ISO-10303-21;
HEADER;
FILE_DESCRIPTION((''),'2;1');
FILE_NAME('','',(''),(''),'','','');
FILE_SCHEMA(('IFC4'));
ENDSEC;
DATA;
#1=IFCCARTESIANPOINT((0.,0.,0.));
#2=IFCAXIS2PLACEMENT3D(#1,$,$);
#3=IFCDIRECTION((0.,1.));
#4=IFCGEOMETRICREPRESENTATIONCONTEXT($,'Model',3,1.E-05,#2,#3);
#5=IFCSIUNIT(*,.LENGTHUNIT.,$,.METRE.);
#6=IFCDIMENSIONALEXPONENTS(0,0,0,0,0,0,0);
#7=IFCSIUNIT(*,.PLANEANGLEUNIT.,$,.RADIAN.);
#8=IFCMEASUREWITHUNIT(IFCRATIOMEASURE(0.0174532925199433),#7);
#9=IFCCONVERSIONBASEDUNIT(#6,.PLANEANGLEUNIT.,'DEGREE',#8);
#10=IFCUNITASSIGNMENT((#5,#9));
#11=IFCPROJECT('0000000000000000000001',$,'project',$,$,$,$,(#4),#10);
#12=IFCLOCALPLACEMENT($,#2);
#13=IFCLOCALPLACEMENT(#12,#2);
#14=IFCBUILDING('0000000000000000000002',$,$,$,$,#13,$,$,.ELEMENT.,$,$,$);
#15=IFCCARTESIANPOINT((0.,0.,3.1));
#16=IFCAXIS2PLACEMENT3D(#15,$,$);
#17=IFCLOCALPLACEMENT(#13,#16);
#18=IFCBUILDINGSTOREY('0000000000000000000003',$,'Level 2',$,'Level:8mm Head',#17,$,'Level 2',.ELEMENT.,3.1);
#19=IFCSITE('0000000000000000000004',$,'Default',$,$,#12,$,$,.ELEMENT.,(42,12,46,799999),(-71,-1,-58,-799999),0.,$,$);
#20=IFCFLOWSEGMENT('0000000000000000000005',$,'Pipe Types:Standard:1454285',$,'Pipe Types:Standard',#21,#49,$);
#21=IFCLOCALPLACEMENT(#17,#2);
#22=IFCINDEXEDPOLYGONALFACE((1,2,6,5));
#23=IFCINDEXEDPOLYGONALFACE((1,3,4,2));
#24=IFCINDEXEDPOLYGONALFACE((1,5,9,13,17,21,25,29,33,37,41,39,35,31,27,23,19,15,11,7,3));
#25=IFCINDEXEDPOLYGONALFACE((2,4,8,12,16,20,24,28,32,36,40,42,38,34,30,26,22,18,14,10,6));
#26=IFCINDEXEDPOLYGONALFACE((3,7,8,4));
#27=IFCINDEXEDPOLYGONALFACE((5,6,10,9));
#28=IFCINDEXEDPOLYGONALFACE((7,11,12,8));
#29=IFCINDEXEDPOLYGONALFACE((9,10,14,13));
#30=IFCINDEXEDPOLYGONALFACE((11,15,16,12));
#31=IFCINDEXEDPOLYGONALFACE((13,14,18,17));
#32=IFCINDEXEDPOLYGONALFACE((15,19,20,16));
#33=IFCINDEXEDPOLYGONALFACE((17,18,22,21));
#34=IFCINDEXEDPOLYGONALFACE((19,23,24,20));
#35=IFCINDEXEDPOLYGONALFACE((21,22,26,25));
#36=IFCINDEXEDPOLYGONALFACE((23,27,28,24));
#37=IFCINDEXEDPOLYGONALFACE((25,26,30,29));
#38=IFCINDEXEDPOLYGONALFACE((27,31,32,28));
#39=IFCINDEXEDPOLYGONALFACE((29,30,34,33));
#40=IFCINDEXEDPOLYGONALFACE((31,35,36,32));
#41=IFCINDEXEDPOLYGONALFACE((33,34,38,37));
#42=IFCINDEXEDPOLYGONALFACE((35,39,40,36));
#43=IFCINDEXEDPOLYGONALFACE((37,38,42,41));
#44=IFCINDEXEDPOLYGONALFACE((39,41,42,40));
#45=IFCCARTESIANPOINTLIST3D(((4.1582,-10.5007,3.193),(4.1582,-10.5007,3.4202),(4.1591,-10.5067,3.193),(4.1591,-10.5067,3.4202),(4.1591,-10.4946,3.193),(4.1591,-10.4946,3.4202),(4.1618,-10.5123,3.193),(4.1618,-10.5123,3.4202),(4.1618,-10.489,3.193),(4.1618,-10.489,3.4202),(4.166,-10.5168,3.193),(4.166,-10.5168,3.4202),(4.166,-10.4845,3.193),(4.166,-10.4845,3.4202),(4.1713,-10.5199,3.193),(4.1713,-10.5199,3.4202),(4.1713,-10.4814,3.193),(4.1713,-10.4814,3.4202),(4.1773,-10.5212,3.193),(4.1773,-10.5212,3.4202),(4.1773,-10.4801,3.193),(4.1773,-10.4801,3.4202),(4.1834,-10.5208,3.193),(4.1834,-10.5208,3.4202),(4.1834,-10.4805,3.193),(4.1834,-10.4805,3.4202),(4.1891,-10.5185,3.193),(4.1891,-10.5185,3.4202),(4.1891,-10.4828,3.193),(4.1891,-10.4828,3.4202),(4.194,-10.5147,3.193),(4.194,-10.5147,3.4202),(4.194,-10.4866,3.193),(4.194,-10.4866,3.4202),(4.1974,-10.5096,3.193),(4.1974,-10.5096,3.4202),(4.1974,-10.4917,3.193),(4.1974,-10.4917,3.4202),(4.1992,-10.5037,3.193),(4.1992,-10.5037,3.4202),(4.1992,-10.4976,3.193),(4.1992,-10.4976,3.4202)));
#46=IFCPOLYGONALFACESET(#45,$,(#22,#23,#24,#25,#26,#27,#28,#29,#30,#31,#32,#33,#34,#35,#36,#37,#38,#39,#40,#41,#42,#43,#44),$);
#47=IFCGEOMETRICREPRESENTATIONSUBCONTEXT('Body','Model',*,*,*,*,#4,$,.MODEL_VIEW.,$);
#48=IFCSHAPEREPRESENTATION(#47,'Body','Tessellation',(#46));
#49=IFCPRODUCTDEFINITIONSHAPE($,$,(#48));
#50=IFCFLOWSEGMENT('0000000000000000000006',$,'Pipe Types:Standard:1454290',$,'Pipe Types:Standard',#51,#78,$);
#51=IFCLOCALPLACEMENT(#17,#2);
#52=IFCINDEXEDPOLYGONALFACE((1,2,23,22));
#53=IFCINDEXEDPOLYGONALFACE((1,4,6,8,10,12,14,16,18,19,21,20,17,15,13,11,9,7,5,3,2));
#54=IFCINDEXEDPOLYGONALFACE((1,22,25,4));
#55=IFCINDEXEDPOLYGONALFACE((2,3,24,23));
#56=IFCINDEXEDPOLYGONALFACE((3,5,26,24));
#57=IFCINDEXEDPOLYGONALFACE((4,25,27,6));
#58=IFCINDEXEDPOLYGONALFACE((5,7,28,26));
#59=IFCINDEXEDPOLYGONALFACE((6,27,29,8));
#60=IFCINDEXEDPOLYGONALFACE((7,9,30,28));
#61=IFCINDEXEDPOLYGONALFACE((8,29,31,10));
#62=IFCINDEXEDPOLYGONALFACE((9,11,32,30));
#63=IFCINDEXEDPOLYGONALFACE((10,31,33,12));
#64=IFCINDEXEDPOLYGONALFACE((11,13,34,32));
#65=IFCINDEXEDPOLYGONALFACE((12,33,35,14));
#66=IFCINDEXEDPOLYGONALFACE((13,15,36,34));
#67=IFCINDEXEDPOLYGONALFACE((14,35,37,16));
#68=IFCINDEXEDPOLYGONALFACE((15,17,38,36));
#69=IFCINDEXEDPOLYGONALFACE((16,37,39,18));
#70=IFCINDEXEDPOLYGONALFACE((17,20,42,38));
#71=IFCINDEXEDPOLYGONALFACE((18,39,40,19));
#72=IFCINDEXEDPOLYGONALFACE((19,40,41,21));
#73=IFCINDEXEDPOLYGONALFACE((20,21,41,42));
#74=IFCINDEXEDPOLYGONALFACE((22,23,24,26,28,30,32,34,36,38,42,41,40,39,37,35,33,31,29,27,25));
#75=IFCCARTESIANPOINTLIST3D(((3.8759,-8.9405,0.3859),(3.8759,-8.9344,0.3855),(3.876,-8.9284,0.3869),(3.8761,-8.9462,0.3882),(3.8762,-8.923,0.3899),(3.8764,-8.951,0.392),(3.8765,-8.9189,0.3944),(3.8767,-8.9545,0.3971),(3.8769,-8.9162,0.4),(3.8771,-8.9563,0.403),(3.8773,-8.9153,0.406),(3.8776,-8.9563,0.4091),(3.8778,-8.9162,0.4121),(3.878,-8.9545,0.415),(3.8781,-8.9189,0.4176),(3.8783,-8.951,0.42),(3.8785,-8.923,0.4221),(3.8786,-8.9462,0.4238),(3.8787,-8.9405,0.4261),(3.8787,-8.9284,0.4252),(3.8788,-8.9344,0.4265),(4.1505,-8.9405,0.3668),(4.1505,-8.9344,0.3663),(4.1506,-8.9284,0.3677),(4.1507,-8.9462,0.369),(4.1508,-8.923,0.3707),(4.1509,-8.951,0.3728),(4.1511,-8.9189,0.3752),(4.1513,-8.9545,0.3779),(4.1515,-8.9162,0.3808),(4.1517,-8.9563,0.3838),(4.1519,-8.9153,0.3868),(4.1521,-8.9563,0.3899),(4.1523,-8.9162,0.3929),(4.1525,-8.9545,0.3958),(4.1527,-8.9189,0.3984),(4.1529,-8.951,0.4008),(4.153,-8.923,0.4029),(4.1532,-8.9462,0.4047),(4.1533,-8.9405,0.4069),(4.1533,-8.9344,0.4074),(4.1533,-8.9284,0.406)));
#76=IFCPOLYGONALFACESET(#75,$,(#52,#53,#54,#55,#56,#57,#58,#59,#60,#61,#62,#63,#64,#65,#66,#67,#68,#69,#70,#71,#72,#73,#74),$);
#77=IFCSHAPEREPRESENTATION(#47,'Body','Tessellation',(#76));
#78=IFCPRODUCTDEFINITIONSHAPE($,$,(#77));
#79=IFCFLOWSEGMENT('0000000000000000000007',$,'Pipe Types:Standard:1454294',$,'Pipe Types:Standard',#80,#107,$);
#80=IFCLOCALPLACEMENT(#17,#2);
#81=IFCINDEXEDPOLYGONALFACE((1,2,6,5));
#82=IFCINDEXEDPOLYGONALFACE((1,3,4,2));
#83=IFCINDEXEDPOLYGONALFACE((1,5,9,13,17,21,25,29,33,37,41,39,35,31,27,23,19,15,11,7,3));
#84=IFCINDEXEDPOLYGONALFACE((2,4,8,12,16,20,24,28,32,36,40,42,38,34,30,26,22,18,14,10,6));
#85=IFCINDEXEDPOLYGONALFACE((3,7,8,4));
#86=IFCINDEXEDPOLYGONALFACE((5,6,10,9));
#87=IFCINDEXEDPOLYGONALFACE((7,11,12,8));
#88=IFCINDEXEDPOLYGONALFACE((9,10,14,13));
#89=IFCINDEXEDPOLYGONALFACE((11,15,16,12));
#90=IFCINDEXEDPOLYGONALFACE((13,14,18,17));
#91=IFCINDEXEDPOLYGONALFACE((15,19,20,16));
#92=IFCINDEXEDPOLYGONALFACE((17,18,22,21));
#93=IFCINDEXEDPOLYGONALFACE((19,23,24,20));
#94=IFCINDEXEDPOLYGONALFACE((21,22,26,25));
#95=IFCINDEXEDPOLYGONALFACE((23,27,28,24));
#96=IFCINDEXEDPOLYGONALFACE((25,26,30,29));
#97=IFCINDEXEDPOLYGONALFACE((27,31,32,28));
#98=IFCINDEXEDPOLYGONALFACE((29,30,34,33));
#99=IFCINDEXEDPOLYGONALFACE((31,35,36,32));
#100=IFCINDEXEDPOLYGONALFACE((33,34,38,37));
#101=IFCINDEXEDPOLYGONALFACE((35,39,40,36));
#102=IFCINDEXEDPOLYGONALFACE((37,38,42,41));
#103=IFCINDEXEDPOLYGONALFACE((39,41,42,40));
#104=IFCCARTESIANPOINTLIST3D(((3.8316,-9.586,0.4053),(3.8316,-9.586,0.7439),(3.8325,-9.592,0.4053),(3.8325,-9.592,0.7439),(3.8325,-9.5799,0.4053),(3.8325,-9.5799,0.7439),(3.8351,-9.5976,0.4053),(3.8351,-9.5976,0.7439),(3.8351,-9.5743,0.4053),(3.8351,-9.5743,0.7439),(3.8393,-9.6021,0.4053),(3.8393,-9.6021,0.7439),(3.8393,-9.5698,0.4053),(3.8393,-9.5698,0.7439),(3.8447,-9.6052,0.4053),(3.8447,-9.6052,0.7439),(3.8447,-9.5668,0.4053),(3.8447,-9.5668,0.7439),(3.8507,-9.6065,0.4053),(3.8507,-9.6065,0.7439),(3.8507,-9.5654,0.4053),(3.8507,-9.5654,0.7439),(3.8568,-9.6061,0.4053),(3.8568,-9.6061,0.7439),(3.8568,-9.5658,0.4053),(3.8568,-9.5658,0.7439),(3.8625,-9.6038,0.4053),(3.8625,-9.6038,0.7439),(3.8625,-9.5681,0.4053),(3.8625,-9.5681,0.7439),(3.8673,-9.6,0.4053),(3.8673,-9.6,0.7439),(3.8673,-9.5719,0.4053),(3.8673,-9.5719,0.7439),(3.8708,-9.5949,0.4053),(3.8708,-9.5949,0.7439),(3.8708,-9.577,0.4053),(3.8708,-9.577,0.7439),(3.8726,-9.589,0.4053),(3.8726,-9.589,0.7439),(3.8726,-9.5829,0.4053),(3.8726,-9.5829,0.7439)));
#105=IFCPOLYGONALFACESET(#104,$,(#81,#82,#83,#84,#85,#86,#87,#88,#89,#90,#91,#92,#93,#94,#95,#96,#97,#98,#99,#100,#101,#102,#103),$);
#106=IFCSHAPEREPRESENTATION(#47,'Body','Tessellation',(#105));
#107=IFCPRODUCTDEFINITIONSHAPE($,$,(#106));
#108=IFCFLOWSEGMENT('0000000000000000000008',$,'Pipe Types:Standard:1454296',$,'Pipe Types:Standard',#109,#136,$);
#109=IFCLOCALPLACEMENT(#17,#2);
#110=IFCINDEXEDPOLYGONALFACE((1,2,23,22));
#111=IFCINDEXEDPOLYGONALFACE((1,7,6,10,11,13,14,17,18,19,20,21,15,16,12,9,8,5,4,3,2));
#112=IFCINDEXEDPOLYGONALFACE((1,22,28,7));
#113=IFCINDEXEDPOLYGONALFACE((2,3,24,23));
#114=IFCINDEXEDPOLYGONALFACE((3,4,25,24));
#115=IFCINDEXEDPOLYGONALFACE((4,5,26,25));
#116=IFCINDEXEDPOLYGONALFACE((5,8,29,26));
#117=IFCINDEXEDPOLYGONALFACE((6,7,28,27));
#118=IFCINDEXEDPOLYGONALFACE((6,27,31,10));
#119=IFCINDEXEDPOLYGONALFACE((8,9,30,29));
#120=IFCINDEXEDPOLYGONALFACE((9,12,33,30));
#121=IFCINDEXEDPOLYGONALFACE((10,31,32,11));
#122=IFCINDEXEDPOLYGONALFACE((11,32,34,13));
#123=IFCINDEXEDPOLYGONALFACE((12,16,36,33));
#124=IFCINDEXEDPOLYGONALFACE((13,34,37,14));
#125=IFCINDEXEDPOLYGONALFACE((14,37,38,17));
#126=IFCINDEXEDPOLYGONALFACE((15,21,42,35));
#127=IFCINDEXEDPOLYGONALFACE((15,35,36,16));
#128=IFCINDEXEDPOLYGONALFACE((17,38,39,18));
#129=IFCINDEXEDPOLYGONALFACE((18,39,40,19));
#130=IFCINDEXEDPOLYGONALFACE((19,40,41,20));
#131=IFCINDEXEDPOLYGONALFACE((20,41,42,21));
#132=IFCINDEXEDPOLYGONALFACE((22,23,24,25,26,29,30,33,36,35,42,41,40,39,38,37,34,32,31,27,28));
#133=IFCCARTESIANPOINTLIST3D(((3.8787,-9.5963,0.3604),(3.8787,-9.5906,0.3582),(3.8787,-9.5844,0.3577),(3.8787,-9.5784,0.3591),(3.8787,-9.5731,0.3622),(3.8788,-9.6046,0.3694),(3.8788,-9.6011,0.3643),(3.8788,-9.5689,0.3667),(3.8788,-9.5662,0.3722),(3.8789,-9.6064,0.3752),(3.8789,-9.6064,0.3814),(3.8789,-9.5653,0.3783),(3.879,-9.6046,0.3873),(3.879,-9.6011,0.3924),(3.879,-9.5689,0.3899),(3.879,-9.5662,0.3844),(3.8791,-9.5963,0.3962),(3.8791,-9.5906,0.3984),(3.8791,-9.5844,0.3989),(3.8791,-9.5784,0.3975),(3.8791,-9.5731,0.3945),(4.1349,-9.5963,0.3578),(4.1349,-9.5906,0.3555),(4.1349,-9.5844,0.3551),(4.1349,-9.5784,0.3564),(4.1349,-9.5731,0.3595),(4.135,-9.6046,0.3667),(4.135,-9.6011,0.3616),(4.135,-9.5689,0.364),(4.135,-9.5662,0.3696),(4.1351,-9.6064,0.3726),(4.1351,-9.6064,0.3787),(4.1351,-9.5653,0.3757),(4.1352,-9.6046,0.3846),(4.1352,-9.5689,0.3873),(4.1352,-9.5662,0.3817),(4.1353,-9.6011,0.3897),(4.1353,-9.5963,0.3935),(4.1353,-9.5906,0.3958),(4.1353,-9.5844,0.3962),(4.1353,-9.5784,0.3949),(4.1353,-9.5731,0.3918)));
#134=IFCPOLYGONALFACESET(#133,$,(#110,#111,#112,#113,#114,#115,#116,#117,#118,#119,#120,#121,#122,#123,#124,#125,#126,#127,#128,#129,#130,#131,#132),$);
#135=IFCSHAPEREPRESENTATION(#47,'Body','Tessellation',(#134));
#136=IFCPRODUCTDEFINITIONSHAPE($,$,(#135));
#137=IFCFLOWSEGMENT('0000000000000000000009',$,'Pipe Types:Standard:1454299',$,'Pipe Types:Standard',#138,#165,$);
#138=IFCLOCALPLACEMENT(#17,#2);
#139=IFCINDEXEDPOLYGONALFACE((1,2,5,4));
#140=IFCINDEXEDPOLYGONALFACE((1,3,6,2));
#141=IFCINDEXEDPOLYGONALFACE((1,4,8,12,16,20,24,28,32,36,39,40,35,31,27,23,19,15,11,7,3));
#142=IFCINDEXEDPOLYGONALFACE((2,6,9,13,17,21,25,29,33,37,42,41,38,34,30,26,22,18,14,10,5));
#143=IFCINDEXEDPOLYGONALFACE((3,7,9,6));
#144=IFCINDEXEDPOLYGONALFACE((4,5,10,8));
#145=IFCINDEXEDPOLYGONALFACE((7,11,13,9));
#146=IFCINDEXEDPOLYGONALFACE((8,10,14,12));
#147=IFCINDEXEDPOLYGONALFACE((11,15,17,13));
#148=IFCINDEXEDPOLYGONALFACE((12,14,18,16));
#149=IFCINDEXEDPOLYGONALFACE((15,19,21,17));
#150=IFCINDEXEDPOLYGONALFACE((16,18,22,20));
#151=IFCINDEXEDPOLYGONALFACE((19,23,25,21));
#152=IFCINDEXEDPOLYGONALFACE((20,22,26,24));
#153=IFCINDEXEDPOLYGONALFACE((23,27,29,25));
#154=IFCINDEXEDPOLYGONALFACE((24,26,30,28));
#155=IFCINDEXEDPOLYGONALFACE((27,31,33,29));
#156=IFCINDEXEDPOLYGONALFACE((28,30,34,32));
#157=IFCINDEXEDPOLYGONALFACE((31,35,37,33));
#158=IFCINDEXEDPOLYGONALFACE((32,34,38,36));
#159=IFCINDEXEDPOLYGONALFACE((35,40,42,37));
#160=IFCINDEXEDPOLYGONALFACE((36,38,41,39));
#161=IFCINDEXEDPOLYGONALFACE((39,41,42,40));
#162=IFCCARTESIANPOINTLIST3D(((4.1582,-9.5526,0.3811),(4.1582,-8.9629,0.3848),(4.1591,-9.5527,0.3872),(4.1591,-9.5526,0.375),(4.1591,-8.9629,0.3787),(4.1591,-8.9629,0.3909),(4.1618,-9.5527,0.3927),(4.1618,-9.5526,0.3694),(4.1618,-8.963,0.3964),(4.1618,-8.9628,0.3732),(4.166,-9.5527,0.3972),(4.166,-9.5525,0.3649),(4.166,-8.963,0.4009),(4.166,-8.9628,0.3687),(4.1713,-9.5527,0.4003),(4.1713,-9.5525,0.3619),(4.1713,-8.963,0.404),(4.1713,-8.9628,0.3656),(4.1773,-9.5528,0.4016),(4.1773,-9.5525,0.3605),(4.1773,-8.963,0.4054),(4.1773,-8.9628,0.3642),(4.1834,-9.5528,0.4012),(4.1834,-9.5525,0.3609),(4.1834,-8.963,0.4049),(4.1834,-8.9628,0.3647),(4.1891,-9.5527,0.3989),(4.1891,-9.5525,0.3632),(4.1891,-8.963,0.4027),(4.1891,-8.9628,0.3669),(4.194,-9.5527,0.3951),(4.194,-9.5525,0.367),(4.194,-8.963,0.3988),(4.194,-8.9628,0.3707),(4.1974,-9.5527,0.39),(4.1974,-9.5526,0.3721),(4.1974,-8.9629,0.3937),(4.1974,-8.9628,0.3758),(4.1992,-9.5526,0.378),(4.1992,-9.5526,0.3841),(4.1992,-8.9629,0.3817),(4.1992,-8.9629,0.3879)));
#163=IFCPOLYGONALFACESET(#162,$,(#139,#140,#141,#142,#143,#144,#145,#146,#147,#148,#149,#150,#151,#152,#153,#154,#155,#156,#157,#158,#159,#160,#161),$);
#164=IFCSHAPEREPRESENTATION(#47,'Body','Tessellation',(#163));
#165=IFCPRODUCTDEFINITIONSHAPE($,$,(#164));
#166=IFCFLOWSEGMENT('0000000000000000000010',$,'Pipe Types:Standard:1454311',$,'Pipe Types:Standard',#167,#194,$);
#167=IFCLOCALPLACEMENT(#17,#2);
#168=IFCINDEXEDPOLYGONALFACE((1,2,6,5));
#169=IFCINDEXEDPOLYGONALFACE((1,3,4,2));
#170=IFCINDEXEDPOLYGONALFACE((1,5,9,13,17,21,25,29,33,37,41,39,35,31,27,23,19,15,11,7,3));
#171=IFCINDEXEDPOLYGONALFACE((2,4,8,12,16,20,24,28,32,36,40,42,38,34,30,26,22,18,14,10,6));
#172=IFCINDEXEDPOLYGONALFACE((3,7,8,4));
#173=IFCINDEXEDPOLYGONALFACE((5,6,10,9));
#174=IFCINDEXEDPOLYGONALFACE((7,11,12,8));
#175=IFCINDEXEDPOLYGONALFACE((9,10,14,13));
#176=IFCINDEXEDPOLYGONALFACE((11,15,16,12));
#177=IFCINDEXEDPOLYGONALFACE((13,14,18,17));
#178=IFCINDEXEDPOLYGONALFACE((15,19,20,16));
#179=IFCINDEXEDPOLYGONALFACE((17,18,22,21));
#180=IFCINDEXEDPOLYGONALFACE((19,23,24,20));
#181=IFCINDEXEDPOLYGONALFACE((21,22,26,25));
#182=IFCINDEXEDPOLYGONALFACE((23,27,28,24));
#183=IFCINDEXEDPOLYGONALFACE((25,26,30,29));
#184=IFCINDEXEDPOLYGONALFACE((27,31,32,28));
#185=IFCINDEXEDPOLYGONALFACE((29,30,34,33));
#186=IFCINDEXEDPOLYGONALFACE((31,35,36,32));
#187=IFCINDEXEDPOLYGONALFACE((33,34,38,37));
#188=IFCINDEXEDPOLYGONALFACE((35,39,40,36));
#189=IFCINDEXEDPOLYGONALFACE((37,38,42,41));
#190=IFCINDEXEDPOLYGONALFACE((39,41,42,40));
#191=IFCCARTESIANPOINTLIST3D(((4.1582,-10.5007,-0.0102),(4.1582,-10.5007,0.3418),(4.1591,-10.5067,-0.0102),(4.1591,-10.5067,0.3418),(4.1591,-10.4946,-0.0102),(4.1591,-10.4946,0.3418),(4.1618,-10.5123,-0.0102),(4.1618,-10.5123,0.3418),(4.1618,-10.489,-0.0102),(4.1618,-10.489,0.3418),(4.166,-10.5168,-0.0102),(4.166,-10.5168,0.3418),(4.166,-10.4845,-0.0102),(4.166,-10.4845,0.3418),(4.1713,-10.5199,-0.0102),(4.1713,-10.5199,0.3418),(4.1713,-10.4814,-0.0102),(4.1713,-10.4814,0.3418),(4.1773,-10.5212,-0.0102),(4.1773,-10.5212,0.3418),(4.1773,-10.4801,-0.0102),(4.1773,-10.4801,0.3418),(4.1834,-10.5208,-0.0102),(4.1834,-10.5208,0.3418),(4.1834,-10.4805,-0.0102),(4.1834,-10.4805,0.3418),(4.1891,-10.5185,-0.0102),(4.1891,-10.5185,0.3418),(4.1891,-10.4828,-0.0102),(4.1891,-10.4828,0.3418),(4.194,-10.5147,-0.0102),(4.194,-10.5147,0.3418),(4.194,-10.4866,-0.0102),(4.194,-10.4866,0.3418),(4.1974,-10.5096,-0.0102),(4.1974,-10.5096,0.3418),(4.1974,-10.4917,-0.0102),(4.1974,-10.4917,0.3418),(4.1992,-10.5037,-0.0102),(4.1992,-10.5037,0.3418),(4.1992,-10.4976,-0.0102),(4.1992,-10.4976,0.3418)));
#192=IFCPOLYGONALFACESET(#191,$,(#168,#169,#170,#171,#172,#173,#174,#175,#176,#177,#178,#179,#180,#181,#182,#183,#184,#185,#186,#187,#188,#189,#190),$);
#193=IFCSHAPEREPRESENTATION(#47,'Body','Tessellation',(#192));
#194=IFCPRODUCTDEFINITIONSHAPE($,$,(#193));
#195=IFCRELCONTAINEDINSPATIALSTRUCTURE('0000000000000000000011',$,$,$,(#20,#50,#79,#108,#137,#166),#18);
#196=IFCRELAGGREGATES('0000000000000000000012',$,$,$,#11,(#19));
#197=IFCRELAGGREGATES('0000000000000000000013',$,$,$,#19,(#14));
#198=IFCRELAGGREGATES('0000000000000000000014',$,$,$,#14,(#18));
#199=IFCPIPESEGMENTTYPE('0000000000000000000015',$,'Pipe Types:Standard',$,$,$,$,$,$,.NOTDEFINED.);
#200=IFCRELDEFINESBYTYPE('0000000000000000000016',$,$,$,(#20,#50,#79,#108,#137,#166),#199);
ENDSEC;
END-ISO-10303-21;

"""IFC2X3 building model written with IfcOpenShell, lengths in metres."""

from ifc_helpers import new_model, entity, si_unit, converted_unit, direction, frame, frame_2d, origin, origin_2d_with_axis, place, context, subcontext, project, spatial, circle, extrude, type_object, element, save


model = new_model("IFC2X3")

# Units and contexts
model_context = context("Model", 3, precision=1e-05, world=origin(), true_north=direction((0.0, 1.0)))
body_context = subcontext(model_context, "Body", "Model", "MODEL_VIEW")
ifc_project = project(units=[si_unit("LENGTHUNIT", "METRE"), converted_unit("PLANEANGLEUNIT", "DEGREE", entity("IfcRatioMeasure", 0.0174532925199433), si_unit("PLANEANGLEUNIT", "RADIAN"), dimensions=[0, 0, 0, 0, 0, 0, 0])], contexts=[model_context])

# Site, building, storey
site_placement = place(None, origin())
site = spatial("IfcSite", under=ifc_project, at=site_placement, Name="Default", CompositionType="ELEMENT", RefLatitude=(42, 12, 46, 799999), RefLongitude=(-71, -1, -58, -799999), RefElevation=0.0)
building_placement = place(site_placement, origin())
building = spatial("IfcBuilding", under=site, at=building_placement, CompositionType="ELEMENT")
storey_placement = place(building_placement, frame((0.0, 0.0, 3.1)))
storey = spatial("IfcBuildingStorey", under=building, at=storey_placement, Name="Level 2", ObjectType="Level:8mm Head", LongName="Level 2", CompositionType="ELEMENT", Elevation=3.1)

# Flow segments
pipe_segment_type = type_object("IfcPipeSegmentType", Name="Pipe Types:Standard", PredefinedType="NOTDEFINED")
flow_segment_1_placement = place(storey_placement, origin())
element("IfcFlowSegment", 1, at=flow_segment_1_placement, inside=storey, type_object=pipe_segment_type, Name="Pipe Types:Standard:1454285", ObjectType="Pipe Types:Standard", context=body_context, shape_type="SweptSolid", body=[
    extrude(circle(Radius=0.0206, at=origin_2d_with_axis()), frame((4.1788, -10.5007, 3.193), z_axis=(0.0, 0.0, 1.0), x_axis=(-1.0, 0.0, 0.0)), (0.0, 0.0, 1.0), 0.2272),
])
flow_segment_2_placement = place(storey_placement, origin())
element("IfcFlowSegment", 2, at=flow_segment_2_placement, inside=storey, type_object=pipe_segment_type, Name="Pipe Types:Standard:1454290", ObjectType="Pipe Types:Standard", context=body_context, shape_type="SweptSolid", body=[
    extrude(circle(Radius=0.0206, at=origin_2d_with_axis()), frame((3.8773, -8.9359, 0.406), z_axis=(0.997568, 0.0, -0.069693), x_axis=(0.0, 1.0, 0.0)), (0.0, 0.0, 1.0), 0.2752),
])
flow_segment_3_placement = place(storey_placement, origin())
element("IfcFlowSegment", 3, at=flow_segment_3_placement, inside=storey, type_object=pipe_segment_type, Name="Pipe Types:Standard:1454294", ObjectType="Pipe Types:Standard", context=body_context, shape_type="SweptSolid", body=[
    extrude(circle(Radius=0.0206, at=frame_2d((0.0, 0.0), x_axis=(1.0, 0.0))), frame((3.8522, -9.586, 0.4053), z_axis=(0.000016, 0.0, 1.0), x_axis=(-1.0, 0.0, 0.000016)), (0.0, 0.0, 1.0), 0.3385),
])
flow_segment_4_placement = place(storey_placement, origin())
element("IfcFlowSegment", 4, at=flow_segment_4_placement, inside=storey, type_object=pipe_segment_type, Name="Pipe Types:Standard:1454296", ObjectType="Pipe Types:Standard", context=body_context, shape_type="SweptSolid", body=[
    extrude(circle(Radius=0.0206, at=origin_2d_with_axis()), frame((4.1351, -9.586, 0.3757), z_axis=(-0.999946, 0.0, 0.010416), x_axis=(0.0, 1.0, 0.0)), (0.0, 0.0, 1.0), 0.2562),
])
flow_segment_5_placement = place(storey_placement, origin())
element("IfcFlowSegment", 5, at=flow_segment_5_placement, inside=storey, type_object=pipe_segment_type, Name="Pipe Types:Standard:1454299", ObjectType="Pipe Types:Standard", context=body_context, shape_type="SweptSolid", body=[
    extrude(circle(Radius=0.0206, at=frame_2d((0.0, 0.0), x_axis=(1.0, 0.0))), frame((4.1788, -9.5526, 0.3811), z_axis=(0.0, 0.99998, 0.006302), x_axis=(-1.0, 0.0, 0.0)), (0.0, 0.0, 1.0), 0.5898),
])
flow_segment_6_placement = place(storey_placement, origin())
element("IfcFlowSegment", 6, at=flow_segment_6_placement, inside=storey, type_object=pipe_segment_type, Name="Pipe Types:Standard:1454311", ObjectType="Pipe Types:Standard", context=body_context, shape_type="SweptSolid", body=[
    extrude(circle(Radius=0.0206, at=origin_2d_with_axis()), frame((4.1788, -10.5007, -0.0102), z_axis=(0.0, 0.0, 1.0), x_axis=(-1.0, 0.0, 0.0)), (0.0, 0.0, 1.0), 0.3519),
])

save(model, "model.ifc")
